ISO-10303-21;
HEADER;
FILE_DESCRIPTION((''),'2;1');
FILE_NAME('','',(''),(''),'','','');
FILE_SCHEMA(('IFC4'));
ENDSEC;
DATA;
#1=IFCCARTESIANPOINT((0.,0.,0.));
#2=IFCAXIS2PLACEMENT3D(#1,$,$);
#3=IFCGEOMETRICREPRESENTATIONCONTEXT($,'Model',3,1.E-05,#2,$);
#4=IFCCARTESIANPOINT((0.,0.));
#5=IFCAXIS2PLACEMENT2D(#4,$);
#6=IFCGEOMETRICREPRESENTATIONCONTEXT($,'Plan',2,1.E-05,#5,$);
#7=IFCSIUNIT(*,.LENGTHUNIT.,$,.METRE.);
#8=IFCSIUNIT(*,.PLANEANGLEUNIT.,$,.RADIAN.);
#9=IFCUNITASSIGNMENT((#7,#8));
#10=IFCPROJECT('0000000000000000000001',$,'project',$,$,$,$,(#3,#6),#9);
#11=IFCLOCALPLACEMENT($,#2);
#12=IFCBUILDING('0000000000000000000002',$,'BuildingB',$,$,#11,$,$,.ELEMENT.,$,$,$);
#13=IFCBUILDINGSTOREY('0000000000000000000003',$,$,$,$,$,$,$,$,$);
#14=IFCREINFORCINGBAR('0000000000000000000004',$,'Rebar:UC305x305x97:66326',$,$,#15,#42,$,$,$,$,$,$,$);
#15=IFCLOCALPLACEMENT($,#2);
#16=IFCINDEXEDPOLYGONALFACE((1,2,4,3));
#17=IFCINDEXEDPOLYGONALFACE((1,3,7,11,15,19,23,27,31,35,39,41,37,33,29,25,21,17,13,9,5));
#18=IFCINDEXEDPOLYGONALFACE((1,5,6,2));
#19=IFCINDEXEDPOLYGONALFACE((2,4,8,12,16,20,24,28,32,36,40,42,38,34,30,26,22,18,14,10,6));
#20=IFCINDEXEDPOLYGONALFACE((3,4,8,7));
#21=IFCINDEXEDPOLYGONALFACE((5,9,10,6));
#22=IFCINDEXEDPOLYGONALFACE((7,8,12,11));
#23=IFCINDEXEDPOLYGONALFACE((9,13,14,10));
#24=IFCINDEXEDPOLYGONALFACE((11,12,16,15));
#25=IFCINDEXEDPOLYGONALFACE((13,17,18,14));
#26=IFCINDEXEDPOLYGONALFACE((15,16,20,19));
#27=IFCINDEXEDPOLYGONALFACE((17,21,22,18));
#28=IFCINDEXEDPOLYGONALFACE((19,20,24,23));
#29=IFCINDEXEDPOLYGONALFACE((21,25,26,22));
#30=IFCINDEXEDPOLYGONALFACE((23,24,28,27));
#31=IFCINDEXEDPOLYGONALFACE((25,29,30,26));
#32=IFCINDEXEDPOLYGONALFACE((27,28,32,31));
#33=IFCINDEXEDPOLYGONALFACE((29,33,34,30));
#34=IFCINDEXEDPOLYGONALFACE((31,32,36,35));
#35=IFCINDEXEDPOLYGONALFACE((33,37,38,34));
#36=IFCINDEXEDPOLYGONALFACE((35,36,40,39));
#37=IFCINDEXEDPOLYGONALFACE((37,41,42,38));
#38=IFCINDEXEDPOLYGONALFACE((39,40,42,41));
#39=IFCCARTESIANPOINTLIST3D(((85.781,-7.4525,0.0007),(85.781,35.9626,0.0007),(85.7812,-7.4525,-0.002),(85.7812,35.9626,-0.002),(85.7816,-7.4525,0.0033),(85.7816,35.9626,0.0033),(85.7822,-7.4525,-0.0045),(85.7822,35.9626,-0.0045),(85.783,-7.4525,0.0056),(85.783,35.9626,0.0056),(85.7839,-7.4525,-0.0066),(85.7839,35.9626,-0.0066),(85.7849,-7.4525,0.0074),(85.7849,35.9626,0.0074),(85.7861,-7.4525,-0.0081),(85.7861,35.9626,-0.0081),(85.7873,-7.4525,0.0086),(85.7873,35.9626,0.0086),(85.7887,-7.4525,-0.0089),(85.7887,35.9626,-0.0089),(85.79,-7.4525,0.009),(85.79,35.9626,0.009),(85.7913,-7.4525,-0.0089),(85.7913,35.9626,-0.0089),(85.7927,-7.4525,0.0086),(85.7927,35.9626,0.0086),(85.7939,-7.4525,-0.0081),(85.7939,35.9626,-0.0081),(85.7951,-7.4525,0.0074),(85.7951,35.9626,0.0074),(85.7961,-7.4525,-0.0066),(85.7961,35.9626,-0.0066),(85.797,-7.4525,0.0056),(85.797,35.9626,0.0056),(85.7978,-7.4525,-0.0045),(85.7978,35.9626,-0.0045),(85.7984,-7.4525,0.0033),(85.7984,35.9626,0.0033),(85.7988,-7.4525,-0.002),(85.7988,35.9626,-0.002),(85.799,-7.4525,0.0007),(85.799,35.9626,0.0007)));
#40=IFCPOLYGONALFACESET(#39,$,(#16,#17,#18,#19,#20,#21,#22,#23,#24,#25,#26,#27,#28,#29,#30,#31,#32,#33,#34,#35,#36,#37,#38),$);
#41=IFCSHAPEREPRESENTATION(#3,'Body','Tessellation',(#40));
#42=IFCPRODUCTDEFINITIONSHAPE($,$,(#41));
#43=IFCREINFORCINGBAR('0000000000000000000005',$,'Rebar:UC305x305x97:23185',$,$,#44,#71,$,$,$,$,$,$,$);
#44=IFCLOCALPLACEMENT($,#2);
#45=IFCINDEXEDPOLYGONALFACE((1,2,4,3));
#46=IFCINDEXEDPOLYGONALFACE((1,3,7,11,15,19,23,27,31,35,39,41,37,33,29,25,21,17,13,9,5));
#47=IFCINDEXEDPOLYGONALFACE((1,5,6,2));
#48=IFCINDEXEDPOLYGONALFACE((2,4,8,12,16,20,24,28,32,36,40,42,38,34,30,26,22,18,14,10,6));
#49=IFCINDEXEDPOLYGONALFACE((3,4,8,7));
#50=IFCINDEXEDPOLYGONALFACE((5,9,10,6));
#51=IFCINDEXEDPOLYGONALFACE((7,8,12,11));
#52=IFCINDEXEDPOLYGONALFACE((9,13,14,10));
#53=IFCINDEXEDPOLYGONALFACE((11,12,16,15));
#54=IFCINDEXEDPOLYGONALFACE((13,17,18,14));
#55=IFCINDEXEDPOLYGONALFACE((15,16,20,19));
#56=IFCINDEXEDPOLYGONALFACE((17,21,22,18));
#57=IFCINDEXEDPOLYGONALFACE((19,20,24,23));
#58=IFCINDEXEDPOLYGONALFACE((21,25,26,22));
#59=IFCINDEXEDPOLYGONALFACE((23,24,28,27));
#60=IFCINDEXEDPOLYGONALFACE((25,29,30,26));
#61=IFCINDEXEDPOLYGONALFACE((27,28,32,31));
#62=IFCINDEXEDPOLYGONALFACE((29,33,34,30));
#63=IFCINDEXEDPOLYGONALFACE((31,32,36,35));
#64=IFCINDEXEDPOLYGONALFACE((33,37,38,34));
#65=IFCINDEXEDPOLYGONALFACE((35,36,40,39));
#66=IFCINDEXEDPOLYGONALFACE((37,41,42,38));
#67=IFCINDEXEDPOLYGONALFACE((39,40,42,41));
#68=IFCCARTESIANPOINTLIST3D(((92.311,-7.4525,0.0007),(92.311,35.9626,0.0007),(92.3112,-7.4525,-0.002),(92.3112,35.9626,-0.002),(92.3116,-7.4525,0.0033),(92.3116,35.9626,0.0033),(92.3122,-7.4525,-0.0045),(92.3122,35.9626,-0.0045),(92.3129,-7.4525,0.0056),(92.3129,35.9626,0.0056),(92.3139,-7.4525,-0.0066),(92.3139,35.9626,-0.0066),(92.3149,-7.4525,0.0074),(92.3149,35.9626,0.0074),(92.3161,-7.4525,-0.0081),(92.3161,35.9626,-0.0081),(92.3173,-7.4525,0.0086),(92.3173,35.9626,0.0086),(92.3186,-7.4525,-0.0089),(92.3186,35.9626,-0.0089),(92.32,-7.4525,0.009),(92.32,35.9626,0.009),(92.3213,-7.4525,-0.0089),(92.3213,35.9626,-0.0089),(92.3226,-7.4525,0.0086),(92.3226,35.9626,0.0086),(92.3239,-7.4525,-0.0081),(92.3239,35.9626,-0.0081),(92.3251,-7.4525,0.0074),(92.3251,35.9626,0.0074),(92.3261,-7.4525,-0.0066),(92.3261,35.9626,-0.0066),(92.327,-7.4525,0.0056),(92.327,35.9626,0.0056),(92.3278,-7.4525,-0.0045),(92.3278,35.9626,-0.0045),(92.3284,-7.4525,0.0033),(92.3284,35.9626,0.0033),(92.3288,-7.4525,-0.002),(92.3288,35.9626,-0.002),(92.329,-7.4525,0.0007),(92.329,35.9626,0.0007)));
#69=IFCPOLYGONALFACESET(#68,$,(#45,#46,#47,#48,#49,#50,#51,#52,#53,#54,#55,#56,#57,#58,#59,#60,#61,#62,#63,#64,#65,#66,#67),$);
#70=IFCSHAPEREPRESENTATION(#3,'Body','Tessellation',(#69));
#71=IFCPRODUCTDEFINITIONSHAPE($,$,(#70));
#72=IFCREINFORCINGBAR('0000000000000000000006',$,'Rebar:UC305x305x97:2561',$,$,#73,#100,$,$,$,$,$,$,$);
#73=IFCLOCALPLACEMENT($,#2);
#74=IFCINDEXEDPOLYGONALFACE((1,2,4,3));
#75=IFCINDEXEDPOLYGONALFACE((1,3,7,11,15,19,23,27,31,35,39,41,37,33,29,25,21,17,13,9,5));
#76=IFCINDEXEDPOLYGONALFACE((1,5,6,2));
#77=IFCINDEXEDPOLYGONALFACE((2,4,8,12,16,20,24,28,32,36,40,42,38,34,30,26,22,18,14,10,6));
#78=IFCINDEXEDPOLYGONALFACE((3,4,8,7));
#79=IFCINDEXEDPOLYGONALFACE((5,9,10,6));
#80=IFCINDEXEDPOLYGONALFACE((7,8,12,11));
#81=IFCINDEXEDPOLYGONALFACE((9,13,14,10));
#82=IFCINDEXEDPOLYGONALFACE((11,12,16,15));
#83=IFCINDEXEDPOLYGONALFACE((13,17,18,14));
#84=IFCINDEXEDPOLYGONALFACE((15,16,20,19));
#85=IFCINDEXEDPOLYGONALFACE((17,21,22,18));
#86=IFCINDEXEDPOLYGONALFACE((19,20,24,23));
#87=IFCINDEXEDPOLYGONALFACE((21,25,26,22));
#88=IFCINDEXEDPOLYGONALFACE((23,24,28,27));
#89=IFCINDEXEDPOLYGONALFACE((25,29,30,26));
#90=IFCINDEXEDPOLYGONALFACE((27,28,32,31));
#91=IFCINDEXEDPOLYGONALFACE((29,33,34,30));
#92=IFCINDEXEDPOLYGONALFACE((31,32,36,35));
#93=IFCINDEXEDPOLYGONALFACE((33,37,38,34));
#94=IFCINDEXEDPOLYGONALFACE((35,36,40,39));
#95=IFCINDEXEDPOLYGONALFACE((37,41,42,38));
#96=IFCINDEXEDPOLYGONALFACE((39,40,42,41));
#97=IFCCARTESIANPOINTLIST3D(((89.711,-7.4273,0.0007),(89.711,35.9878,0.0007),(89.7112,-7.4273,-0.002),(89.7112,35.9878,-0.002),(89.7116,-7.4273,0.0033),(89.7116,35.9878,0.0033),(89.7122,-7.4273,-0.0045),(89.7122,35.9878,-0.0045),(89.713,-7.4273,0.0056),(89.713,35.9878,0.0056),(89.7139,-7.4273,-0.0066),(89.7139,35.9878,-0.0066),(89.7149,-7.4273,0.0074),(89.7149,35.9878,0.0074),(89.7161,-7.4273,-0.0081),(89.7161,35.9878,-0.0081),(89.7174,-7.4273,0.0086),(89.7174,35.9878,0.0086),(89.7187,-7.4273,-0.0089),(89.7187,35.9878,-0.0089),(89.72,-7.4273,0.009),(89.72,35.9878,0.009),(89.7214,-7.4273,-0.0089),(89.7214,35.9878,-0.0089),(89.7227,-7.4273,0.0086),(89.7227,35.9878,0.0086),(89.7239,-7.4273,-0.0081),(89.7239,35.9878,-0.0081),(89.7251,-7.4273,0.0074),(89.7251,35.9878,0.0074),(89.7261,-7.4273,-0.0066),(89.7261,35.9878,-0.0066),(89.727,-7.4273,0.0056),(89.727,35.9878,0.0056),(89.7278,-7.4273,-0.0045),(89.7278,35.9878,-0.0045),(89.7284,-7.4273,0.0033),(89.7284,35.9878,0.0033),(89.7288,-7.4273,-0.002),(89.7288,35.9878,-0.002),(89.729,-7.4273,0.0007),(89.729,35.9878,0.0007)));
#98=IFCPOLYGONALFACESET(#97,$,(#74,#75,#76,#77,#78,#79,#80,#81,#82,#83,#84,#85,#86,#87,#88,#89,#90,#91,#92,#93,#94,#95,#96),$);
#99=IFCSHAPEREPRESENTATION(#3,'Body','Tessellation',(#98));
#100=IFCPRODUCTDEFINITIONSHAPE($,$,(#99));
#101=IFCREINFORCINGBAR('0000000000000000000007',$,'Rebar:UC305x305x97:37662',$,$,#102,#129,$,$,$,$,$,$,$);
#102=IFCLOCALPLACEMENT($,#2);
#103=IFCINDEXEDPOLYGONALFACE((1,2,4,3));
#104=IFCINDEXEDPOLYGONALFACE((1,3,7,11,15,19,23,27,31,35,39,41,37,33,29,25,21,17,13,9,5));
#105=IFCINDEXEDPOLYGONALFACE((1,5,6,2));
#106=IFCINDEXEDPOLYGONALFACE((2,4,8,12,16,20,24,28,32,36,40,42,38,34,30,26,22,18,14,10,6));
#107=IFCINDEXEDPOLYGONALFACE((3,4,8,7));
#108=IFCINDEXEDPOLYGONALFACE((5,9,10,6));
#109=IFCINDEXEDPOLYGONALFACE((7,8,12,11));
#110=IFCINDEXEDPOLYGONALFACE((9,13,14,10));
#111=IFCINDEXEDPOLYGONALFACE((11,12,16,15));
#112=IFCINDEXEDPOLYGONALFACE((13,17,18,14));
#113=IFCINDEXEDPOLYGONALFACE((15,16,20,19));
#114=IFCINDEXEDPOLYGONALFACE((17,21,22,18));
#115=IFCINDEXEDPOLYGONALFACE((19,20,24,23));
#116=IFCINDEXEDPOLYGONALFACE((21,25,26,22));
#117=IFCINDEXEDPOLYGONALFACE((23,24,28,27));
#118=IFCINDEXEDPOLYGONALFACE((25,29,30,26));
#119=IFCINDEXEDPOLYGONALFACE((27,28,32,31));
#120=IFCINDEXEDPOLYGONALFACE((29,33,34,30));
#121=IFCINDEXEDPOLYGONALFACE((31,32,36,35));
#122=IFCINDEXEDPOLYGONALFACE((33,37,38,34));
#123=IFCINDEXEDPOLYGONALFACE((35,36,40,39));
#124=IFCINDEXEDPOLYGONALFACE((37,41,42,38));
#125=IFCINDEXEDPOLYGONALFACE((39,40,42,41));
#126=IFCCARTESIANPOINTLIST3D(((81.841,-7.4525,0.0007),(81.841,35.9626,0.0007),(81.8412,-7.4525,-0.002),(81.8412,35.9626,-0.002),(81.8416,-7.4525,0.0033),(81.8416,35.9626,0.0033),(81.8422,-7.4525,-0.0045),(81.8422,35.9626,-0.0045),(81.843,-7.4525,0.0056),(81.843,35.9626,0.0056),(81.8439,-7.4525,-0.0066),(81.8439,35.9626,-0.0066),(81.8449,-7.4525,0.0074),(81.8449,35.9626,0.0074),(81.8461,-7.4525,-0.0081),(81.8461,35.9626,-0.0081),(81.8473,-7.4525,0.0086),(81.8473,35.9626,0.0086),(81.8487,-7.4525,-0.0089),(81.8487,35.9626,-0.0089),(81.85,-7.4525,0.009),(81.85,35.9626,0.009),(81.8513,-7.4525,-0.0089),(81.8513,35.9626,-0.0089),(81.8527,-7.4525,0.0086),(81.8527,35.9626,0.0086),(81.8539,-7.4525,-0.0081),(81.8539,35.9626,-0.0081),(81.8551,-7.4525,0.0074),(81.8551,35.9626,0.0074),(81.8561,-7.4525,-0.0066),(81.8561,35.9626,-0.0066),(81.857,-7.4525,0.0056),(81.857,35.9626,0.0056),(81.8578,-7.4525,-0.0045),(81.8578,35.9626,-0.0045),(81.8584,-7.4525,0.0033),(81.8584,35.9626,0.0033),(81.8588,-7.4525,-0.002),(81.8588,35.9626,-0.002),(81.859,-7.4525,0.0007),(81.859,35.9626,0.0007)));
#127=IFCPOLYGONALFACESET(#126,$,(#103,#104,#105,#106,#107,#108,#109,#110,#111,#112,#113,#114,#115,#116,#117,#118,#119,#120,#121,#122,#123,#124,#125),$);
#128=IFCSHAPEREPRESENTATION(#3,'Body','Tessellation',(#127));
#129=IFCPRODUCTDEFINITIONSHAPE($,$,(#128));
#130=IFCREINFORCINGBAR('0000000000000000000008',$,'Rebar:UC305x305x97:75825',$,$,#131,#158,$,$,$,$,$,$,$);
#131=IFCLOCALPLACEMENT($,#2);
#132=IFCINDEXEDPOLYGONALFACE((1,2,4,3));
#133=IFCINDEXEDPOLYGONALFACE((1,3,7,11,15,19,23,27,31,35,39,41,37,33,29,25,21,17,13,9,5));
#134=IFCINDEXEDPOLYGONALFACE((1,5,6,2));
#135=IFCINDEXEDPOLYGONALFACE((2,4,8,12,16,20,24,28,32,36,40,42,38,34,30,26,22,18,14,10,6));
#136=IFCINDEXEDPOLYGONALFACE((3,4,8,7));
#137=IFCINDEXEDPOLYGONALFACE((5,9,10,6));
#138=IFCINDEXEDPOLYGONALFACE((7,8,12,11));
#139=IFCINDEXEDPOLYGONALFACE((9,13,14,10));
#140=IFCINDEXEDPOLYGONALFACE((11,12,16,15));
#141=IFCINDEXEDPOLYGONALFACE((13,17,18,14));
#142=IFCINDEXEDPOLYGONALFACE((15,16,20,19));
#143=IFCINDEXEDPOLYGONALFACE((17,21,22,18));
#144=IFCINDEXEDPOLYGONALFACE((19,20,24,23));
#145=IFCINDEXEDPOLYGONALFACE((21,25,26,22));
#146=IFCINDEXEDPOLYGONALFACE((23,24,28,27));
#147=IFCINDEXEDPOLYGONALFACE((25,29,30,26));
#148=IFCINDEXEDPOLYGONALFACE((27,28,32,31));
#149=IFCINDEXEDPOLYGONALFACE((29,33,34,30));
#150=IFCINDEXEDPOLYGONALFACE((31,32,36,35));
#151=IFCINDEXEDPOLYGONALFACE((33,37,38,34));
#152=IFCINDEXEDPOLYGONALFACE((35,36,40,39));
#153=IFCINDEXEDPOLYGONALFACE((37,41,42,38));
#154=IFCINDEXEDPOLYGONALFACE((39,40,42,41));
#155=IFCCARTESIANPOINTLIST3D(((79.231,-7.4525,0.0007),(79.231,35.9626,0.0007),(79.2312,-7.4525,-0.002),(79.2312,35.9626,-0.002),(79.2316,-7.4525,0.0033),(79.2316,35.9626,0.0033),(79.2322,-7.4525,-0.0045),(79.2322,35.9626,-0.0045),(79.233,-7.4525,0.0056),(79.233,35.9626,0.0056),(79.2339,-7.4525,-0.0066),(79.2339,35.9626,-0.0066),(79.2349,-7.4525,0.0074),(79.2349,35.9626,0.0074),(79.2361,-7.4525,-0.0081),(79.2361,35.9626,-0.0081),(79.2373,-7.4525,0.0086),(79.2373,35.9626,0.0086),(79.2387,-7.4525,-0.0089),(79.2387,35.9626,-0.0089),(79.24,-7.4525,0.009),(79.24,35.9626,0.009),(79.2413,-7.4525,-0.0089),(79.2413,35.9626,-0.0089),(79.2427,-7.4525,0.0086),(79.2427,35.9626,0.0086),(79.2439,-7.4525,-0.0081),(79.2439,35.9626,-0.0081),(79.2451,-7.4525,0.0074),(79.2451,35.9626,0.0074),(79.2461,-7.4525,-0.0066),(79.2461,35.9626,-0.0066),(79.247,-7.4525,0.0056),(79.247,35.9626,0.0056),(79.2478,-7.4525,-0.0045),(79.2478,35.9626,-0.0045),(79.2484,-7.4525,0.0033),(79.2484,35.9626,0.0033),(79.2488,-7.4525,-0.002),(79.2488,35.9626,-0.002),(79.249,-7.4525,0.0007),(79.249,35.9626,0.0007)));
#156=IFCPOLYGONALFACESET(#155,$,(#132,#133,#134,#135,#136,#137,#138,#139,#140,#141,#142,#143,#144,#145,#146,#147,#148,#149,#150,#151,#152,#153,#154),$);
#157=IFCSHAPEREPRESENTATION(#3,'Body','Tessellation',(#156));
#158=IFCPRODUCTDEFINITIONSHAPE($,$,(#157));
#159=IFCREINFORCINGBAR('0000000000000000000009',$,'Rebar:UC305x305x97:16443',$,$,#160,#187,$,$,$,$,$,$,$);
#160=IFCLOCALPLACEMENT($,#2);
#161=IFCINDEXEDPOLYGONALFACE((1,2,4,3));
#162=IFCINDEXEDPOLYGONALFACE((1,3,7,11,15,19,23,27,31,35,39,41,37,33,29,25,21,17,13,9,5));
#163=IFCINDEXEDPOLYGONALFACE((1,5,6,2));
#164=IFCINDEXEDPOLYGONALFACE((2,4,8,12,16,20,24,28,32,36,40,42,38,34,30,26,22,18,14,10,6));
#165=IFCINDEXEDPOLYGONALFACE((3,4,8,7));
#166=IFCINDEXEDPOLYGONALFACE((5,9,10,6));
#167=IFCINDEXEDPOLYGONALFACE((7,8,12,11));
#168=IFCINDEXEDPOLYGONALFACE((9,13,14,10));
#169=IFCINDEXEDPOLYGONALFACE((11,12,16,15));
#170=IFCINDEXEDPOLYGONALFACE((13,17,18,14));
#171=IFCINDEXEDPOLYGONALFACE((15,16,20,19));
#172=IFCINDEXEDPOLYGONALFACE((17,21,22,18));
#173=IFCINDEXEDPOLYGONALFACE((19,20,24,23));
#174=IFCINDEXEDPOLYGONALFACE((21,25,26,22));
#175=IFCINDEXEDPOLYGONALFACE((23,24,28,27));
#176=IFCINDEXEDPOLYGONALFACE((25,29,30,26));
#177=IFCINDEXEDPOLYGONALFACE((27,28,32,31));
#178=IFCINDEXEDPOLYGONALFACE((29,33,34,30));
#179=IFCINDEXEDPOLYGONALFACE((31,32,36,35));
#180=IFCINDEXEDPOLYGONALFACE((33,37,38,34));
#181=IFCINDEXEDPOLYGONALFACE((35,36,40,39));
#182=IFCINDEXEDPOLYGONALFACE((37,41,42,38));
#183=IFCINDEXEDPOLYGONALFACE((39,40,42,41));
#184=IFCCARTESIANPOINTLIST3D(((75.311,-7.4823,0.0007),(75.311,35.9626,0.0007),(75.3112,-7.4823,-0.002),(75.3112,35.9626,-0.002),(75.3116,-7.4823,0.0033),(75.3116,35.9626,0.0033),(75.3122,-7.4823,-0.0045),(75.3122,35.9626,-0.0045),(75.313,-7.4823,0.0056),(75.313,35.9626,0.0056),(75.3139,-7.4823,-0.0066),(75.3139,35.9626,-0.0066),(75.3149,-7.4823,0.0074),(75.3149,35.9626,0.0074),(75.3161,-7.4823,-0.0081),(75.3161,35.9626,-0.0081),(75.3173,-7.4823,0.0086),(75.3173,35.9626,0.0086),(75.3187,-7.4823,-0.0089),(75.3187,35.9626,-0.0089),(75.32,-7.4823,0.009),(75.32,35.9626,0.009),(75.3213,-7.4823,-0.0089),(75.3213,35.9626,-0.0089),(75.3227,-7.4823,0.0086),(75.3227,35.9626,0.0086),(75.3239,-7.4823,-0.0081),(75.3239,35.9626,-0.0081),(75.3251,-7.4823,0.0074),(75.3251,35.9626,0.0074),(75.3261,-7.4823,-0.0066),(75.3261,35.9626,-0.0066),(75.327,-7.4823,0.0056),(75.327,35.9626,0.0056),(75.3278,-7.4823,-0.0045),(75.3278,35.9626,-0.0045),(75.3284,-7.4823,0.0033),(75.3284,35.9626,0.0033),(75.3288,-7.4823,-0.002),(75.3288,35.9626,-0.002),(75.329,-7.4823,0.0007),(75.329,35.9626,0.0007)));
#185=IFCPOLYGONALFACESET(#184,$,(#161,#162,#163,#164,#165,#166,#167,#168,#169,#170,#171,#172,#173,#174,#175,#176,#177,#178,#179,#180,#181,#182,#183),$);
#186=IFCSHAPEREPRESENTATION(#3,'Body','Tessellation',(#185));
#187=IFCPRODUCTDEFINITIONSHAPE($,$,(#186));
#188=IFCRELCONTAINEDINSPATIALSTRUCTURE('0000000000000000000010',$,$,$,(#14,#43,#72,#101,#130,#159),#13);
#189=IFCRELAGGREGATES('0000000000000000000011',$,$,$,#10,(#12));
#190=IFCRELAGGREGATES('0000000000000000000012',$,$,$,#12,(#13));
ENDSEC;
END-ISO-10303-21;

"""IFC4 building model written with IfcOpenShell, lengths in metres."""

from ifc_helpers import new_model, entity, si_unit, origin, origin_2d, place, context, project, spatial, element, save


model = new_model("IFC4")

# Units and contexts
model_context = context("Model", 3, precision=1e-05, world=origin())
plan_context = context("Plan", 2, precision=1e-05, world=origin_2d())
ifc_project = project(units=[si_unit("LENGTHUNIT", "METRE"), si_unit("PLANEANGLEUNIT", "RADIAN")], contexts=[model_context, plan_context])

# Building, storey
building_placement = place(None, origin())
building = spatial("IfcBuilding", under=ifc_project, at=building_placement, Name="BuildingB", CompositionType="ELEMENT")
storey = spatial("IfcBuildingStorey", under=building)

# Reinforcing bars
element("IfcReinforcingBar", 1, inside=storey, Name="Rebar:UC305x305x97:66326", context=model_context, shape_type="SweptSolid", body=[
    entity("IfcSurfaceCurveSweptAreaSolid", entity("IfcCircleProfileDef", "AREA", None, None, 0.009), None, entity("IfcPolyline", [entity("IfcCartesianPoint", [85.79, 35.9626, 0.0]), entity("IfcCartesianPoint", [85.79, -7.4525, 0.0])]), None, None, entity("IfcPlane", entity("IfcAxis2Placement3D", entity("IfcCartesianPoint", [85.79, 35.9626, 0.0]), entity("IfcDirection", [0.0, 0.0, 1.0]), entity("IfcDirection", [1.0, 0.0, 0.0])))),
])
element("IfcReinforcingBar", 2, inside=storey, Name="Rebar:UC305x305x97:23185", context=model_context, shape_type="SweptSolid", body=[
    entity("IfcSurfaceCurveSweptAreaSolid", entity("IfcCircleProfileDef", "AREA", None, None, 0.009), None, entity("IfcPolyline", [entity("IfcCartesianPoint", [92.32, 35.9626, 0.0]), entity("IfcCartesianPoint", [92.32, -7.4525, 0.0])]), None, None, entity("IfcPlane", entity("IfcAxis2Placement3D", entity("IfcCartesianPoint", [92.32, 35.9626, 0.0]), entity("IfcDirection", [0.0, 0.0, 1.0]), entity("IfcDirection", [1.0, 0.0, 0.0])))),
])
element("IfcReinforcingBar", 3, inside=storey, Name="Rebar:UC305x305x97:2561", context=model_context, shape_type="SweptSolid", body=[
    entity("IfcSurfaceCurveSweptAreaSolid", entity("IfcCircleProfileDef", "AREA", None, None, 0.009), None, entity("IfcPolyline", [entity("IfcCartesianPoint", [89.72, 35.9878, 0.0]), entity("IfcCartesianPoint", [89.72, -7.4273, 0.0])]), None, None, entity("IfcPlane", entity("IfcAxis2Placement3D", entity("IfcCartesianPoint", [89.72, 35.9878, 0.0]), entity("IfcDirection", [0.0, 0.0, 1.0]), entity("IfcDirection", [1.0, 0.0, 0.0])))),
])
element("IfcReinforcingBar", 4, inside=storey, Name="Rebar:UC305x305x97:37662", context=model_context, shape_type="SweptSolid", body=[
    entity("IfcSurfaceCurveSweptAreaSolid", entity("IfcCircleProfileDef", "AREA", None, None, 0.009), None, entity("IfcPolyline", [entity("IfcCartesianPoint", [81.85, 35.9626, 0.0]), entity("IfcCartesianPoint", [81.85, -7.4525, 0.0])]), None, None, entity("IfcPlane", entity("IfcAxis2Placement3D", entity("IfcCartesianPoint", [81.85, 35.9626, 0.0]), entity("IfcDirection", [0.0, 0.0, 1.0]), entity("IfcDirection", [1.0, 0.0, 0.0])))),
])
element("IfcReinforcingBar", 5, inside=storey, Name="Rebar:UC305x305x97:75825", context=model_context, shape_type="SweptSolid", body=[
    entity("IfcSurfaceCurveSweptAreaSolid", entity("IfcCircleProfileDef", "AREA", None, None, 0.009), None, entity("IfcPolyline", [entity("IfcCartesianPoint", [79.24, 35.9626, 0.0]), entity("IfcCartesianPoint", [79.24, -7.4525, 0.0])]), None, None, entity("IfcPlane", entity("IfcAxis2Placement3D", entity("IfcCartesianPoint", [79.24, 35.9626, 0.0]), entity("IfcDirection", [0.0, 0.0, 1.0]), entity("IfcDirection", [1.0, 0.0, 0.0])))),
])
element("IfcReinforcingBar", 6, inside=storey, Name="Rebar:UC305x305x97:16443", context=model_context, shape_type="SweptSolid", body=[
    entity("IfcSurfaceCurveSweptAreaSolid", entity("IfcCircleProfileDef", "AREA", None, None, 0.009), None, entity("IfcPolyline", [entity("IfcCartesianPoint", [75.32, 35.9626, 0.0]), entity("IfcCartesianPoint", [75.32, -7.4823, 0.0])]), None, None, entity("IfcPlane", entity("IfcAxis2Placement3D", entity("IfcCartesianPoint", [75.32, 35.9626, 0.0]), entity("IfcDirection", [0.0, 0.0, 1.0]), entity("IfcDirection", [1.0, 0.0, 0.0])))),
])

save(model, "model.ifc")
